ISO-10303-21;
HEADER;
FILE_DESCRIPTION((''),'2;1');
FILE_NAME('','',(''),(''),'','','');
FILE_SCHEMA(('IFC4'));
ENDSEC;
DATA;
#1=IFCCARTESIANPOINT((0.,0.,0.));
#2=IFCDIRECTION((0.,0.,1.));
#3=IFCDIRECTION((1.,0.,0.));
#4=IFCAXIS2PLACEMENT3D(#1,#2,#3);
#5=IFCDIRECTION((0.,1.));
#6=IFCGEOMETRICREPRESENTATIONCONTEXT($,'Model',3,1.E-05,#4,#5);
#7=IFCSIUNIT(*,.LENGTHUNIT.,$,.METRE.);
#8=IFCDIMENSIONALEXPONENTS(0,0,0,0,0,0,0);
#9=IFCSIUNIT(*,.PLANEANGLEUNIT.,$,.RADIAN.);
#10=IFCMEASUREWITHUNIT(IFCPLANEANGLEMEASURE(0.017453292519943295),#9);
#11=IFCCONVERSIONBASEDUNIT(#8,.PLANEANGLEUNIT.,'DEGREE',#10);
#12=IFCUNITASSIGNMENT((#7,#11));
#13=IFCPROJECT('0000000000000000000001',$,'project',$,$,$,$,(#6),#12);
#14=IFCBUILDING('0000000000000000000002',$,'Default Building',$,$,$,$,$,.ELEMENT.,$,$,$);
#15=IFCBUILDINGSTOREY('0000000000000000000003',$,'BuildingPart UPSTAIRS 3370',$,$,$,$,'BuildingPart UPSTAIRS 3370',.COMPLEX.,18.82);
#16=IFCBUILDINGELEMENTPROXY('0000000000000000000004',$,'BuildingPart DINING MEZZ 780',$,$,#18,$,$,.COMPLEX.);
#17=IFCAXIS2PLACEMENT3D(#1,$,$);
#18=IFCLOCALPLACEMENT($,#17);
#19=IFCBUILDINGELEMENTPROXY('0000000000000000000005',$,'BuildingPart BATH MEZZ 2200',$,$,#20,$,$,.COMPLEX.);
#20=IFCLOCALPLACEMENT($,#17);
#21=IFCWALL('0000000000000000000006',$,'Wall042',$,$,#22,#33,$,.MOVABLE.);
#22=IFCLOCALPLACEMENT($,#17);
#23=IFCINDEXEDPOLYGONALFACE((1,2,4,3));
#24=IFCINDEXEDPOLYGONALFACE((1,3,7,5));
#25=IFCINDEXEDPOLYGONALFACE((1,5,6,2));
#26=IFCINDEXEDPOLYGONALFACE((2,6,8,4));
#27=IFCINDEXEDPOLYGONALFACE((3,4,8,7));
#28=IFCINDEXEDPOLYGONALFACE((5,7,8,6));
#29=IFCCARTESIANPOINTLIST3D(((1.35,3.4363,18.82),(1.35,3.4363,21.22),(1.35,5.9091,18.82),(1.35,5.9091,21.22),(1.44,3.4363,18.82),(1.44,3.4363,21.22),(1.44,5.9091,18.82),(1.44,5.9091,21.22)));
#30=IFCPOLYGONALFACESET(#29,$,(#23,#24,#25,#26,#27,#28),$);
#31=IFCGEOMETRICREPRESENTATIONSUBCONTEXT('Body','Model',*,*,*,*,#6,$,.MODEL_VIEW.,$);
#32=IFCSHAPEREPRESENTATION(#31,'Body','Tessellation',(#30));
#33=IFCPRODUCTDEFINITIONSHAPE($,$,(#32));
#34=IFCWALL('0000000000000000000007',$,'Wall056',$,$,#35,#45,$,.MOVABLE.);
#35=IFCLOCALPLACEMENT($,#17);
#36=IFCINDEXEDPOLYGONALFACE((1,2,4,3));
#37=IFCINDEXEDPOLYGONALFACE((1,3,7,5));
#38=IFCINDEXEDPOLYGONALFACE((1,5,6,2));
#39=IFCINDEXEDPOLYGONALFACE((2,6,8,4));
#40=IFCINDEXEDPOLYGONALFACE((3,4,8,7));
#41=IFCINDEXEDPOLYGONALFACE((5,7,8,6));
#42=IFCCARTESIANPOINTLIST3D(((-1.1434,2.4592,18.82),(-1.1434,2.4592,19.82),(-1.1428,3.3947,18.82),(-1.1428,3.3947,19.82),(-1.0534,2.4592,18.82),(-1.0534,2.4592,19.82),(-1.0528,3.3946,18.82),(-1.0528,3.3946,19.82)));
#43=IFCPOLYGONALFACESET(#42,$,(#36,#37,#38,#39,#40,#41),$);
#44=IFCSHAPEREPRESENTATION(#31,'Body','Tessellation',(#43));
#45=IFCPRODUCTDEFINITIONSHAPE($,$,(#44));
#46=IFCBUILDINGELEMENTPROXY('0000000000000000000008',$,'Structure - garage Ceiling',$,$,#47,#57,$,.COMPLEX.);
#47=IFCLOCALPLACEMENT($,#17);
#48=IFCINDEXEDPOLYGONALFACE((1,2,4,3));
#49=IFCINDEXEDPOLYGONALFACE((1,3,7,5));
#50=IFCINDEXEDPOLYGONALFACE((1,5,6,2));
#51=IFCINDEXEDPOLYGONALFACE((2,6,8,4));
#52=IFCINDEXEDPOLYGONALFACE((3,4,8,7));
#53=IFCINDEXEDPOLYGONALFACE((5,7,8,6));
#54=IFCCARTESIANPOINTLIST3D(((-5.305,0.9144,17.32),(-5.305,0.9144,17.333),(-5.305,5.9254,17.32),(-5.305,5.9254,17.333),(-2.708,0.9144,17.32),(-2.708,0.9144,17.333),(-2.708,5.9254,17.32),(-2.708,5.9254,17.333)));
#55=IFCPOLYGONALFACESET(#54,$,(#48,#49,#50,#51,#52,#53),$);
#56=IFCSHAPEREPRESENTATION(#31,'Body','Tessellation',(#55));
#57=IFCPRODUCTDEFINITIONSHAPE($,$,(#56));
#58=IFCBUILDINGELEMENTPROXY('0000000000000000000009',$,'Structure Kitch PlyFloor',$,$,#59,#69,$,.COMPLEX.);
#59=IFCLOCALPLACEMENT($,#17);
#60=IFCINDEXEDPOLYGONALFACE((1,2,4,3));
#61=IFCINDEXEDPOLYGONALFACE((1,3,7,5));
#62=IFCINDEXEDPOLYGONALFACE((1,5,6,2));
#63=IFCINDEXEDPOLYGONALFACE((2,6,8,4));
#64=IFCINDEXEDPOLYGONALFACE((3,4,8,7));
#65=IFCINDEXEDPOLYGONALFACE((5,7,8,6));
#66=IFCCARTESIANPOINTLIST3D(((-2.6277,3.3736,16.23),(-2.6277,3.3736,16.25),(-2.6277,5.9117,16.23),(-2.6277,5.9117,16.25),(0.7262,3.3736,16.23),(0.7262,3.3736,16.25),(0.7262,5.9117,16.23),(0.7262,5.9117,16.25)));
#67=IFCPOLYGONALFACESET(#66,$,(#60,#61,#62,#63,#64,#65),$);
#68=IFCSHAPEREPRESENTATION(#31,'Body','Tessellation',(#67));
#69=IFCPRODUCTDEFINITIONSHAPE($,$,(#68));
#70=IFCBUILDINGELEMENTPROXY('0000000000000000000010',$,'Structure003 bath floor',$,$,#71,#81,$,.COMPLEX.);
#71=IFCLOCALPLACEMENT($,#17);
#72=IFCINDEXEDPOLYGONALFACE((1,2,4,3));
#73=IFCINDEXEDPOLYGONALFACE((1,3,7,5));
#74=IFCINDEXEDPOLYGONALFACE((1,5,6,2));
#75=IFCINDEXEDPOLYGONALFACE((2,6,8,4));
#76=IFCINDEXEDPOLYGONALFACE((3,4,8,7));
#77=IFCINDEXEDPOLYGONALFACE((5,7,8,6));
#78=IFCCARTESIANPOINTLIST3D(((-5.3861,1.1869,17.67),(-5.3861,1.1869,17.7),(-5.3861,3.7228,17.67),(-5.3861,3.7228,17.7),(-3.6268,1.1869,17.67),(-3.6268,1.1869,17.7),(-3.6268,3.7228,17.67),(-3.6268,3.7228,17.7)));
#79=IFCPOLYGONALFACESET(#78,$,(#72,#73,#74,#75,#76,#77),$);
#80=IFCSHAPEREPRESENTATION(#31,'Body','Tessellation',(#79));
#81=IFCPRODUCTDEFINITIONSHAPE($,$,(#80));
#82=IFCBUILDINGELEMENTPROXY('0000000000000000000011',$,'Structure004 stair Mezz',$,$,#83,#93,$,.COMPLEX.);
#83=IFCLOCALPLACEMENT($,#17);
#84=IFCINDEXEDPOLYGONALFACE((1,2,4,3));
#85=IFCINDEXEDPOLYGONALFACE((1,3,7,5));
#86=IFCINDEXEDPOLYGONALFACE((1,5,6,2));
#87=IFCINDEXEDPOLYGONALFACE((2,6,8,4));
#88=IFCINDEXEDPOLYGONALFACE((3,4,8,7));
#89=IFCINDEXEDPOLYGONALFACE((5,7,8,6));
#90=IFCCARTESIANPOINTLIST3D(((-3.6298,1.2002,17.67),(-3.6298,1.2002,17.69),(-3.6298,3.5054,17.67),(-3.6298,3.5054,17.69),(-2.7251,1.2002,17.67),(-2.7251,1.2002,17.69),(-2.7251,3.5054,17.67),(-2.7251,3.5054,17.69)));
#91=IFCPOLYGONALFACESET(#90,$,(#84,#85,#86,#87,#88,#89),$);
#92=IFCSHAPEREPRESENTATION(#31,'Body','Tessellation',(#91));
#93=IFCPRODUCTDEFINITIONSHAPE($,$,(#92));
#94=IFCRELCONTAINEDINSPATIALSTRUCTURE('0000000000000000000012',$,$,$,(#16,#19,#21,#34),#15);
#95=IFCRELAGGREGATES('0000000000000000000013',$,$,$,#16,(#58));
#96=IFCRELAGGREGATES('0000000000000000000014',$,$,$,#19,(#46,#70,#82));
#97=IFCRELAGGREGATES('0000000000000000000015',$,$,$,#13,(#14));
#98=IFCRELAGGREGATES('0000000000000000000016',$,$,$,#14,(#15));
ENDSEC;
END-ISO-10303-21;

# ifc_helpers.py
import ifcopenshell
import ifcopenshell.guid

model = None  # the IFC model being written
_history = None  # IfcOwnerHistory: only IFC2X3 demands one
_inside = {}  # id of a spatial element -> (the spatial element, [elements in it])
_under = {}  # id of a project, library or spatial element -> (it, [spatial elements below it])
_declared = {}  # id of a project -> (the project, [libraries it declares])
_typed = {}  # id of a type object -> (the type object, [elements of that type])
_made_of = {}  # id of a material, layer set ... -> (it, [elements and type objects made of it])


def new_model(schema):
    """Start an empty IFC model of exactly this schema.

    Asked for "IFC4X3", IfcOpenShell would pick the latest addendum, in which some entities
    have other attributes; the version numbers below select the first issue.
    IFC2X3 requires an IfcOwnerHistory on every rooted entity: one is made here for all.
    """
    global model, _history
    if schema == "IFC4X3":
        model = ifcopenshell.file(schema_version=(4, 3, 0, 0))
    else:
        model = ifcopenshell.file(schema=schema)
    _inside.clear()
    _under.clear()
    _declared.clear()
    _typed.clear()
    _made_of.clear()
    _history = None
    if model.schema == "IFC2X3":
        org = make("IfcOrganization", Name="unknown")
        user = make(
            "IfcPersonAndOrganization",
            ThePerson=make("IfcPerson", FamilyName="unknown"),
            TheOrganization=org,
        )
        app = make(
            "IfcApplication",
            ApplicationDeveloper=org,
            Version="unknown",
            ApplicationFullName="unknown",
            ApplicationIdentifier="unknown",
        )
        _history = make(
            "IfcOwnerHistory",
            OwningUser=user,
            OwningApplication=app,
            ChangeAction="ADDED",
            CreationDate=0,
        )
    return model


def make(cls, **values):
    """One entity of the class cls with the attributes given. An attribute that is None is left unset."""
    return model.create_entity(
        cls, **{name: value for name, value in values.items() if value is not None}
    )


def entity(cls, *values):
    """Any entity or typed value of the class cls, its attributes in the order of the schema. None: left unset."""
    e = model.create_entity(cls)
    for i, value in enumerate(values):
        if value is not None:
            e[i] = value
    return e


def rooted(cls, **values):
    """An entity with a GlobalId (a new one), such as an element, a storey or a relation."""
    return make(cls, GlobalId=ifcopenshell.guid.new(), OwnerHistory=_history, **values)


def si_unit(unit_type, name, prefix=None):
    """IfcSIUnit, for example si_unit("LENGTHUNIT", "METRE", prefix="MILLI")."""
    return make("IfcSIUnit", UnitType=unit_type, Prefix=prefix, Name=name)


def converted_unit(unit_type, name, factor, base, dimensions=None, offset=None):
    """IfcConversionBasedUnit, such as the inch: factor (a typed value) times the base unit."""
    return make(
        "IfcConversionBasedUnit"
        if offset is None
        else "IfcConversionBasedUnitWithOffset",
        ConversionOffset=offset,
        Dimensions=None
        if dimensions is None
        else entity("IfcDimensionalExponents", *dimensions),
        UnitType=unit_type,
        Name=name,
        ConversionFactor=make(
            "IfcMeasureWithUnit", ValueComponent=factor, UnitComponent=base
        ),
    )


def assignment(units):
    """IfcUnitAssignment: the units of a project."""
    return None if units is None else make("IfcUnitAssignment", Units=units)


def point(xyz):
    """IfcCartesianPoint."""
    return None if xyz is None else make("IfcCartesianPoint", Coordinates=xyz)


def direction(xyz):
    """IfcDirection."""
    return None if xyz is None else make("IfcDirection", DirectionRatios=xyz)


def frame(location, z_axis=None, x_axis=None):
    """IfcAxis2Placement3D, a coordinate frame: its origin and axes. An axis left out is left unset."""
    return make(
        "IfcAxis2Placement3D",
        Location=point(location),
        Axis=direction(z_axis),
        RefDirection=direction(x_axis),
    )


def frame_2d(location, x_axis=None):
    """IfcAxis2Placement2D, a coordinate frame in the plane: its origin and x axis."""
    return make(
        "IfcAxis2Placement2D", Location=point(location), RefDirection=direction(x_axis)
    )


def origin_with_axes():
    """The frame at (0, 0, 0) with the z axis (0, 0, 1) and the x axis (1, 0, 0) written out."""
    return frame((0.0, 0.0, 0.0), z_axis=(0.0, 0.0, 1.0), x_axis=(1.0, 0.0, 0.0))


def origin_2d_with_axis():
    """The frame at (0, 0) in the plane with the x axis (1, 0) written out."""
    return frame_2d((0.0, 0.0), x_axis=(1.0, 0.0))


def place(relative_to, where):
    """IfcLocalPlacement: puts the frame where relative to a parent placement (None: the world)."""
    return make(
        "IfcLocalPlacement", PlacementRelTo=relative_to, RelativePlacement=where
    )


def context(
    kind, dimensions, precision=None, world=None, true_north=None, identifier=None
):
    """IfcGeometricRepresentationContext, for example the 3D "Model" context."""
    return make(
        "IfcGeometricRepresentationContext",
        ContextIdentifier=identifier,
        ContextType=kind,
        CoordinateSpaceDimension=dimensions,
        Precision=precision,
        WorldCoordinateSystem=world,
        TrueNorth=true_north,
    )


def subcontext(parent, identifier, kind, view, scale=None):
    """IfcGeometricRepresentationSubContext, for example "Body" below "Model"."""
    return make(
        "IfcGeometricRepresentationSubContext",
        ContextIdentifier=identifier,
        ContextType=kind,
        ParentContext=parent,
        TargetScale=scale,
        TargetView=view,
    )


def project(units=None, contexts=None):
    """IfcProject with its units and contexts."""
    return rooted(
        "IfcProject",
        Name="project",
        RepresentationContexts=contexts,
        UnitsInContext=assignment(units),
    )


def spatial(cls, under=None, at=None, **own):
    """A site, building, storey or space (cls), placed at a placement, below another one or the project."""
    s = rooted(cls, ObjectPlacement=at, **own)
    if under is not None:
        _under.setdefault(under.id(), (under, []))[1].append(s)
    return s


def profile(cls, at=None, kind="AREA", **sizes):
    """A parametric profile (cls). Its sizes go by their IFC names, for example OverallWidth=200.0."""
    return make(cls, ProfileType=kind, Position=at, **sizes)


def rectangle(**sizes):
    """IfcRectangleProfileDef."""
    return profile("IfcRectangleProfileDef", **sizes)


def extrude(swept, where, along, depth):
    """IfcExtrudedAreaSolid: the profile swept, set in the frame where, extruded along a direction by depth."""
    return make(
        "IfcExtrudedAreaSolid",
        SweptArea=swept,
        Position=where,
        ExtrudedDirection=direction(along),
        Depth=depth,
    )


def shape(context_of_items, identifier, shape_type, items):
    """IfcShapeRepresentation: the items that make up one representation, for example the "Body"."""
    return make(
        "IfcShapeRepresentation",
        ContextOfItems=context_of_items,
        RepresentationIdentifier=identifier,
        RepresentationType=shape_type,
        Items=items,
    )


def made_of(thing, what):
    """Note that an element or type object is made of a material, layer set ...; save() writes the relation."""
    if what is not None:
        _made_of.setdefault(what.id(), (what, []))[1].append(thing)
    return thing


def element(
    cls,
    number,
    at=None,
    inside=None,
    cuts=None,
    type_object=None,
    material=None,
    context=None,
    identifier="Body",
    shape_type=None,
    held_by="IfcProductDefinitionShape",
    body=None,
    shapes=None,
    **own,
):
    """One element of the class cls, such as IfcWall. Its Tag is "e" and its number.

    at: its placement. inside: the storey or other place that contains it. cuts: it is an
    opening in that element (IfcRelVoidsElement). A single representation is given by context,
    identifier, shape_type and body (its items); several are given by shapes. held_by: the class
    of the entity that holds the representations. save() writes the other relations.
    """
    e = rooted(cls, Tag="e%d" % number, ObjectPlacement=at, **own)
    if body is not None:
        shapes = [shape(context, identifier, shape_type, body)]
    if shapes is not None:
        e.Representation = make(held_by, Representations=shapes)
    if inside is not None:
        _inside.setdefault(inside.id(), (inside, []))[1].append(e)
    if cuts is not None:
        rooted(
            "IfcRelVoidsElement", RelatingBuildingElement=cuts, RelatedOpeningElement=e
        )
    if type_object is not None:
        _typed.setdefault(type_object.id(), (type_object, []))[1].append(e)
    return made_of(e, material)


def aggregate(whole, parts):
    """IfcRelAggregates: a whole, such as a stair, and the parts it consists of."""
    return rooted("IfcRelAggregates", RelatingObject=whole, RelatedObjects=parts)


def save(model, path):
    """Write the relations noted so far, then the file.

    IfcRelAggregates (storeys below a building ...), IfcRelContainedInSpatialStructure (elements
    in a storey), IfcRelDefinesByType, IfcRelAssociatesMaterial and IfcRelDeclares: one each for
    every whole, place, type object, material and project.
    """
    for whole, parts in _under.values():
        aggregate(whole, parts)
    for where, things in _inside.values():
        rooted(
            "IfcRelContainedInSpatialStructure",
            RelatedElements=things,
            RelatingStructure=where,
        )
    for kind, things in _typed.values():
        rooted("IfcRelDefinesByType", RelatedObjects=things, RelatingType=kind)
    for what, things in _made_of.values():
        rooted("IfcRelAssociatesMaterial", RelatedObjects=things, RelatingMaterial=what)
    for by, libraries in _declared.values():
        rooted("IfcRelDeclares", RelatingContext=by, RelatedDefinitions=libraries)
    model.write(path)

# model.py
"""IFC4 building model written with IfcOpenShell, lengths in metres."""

from ifc_helpers import new_model, entity, si_unit, converted_unit, direction, frame, frame_2d, origin_with_axes, origin_2d_with_axis, place, context, subcontext, project, spatial, rectangle, extrude, element, aggregate, save


model = new_model("IFC4")

# Units and contexts
model_context = context("Model", 3, precision=1e-05, world=origin_with_axes(), true_north=direction((0.0, 1.0)))
body_context = subcontext(model_context, "Body", "Model", "MODEL_VIEW")
ifc_project = project(units=[si_unit("LENGTHUNIT", "METRE"), converted_unit("PLANEANGLEUNIT", "DEGREE", entity("IfcPlaneAngleMeasure", 0.017453292519943295), si_unit("PLANEANGLEUNIT", "RADIAN"), dimensions=[0, 0, 0, 0, 0, 0, 0])], contexts=[model_context])

# Building, storey
building = spatial("IfcBuilding", under=ifc_project, Name="Default Building", CompositionType="ELEMENT")
storey = spatial("IfcBuildingStorey", under=building, Name="BuildingPart UPSTAIRS 3370", LongName="BuildingPart UPSTAIRS 3370", CompositionType="COMPLEX", Elevation=18.82)

# Building element proxy
proxy_1 = element("IfcBuildingElementProxy", 1, inside=storey, Name="BuildingPart DINING MEZZ 780", PredefinedType="COMPLEX")
placement = place(None, origin_with_axes())

# Building element proxy
proxy_2 = element("IfcBuildingElementProxy", 2, inside=storey, Name="BuildingPart BATH MEZZ 2200", PredefinedType="COMPLEX")

# Walls
element("IfcWall", 3, at=placement, inside=storey, Name="Wall042", PredefinedType="MOVABLE", context=body_context, shape_type="SweptSolid", body=[
    extrude(rectangle(XDim=2.4728, YDim=0.09, at=frame_2d((0.0, 0.0), x_axis=(0.0, -1.0))), frame((1.395, 4.6727, 18.82), z_axis=(0.0, 0.0, 1.0), x_axis=(1.0, 0.0, 0.0)), (0.0, 0.0, 1.0), 2.4),
])
element("IfcWall", 4, at=placement, inside=storey, Name="Wall056", PredefinedType="MOVABLE", context=body_context, shape_type="SweptSolid", body=[
    extrude(rectangle(XDim=0.9354, YDim=0.09, at=frame_2d((0.0, 0.0), x_axis=(-0.000605, -1.0))), frame((-1.0981, 2.9269, 18.82), z_axis=(0.0, 0.0, 1.0), x_axis=(1.0, 0.0, 0.0)), (0.0, 0.0, 1.0), 1.0),
])

# Building element proxies
proxy_3 = element("IfcBuildingElementProxy", 5, at=placement, Name="Structure - garage Ceiling", PredefinedType="COMPLEX", context=body_context, shape_type="SweptSolid", body=[
    extrude(rectangle(XDim=2.597, YDim=5.0109, at=origin_2d_with_axis()), frame((-4.0065, 3.4199, 17.32), z_axis=(0.0, 0.0, 1.0), x_axis=(1.0, 0.0, 0.0)), (0.0, 0.0, 1.0), 0.013),
])
proxy_4 = element("IfcBuildingElementProxy", 6, at=placement, Name="Structure Kitch PlyFloor", PredefinedType="COMPLEX", context=body_context, shape_type="SweptSolid", body=[
    extrude(rectangle(XDim=3.3538, YDim=2.5381, at=origin_2d_with_axis()), frame((-0.9508, 4.6427, 16.23), z_axis=(0.0, 0.0, 1.0), x_axis=(1.0, 0.0, 0.0)), (0.0, 0.0, 1.0), 0.02),
])
aggregate(proxy_1, [proxy_4])
proxy_5 = element("IfcBuildingElementProxy", 7, at=placement, Name="Structure003 bath floor", PredefinedType="COMPLEX", context=body_context, shape_type="SweptSolid", body=[
    extrude(rectangle(XDim=1.7593, YDim=2.5359, at=origin_2d_with_axis()), frame((-4.5065, 2.4549, 17.67), z_axis=(0.0, 0.0, 1.0), x_axis=(1.0, 0.0, 0.0)), (0.0, 0.0, 1.0), 0.03),
])
proxy_6 = element("IfcBuildingElementProxy", 8, at=placement, Name="Structure004 stair Mezz", PredefinedType="COMPLEX", context=body_context, shape_type="SweptSolid", body=[
    extrude(rectangle(XDim=0.9047, YDim=2.3052, at=origin_2d_with_axis()), frame((-3.1775, 2.3528, 17.67), z_axis=(0.0, 0.0, 1.0), x_axis=(1.0, 0.0, 0.0)), (0.0, 0.0, 1.0), 0.02),
])
aggregate(proxy_2, [proxy_3, proxy_5, proxy_6])

save(model, "model.ifc")
